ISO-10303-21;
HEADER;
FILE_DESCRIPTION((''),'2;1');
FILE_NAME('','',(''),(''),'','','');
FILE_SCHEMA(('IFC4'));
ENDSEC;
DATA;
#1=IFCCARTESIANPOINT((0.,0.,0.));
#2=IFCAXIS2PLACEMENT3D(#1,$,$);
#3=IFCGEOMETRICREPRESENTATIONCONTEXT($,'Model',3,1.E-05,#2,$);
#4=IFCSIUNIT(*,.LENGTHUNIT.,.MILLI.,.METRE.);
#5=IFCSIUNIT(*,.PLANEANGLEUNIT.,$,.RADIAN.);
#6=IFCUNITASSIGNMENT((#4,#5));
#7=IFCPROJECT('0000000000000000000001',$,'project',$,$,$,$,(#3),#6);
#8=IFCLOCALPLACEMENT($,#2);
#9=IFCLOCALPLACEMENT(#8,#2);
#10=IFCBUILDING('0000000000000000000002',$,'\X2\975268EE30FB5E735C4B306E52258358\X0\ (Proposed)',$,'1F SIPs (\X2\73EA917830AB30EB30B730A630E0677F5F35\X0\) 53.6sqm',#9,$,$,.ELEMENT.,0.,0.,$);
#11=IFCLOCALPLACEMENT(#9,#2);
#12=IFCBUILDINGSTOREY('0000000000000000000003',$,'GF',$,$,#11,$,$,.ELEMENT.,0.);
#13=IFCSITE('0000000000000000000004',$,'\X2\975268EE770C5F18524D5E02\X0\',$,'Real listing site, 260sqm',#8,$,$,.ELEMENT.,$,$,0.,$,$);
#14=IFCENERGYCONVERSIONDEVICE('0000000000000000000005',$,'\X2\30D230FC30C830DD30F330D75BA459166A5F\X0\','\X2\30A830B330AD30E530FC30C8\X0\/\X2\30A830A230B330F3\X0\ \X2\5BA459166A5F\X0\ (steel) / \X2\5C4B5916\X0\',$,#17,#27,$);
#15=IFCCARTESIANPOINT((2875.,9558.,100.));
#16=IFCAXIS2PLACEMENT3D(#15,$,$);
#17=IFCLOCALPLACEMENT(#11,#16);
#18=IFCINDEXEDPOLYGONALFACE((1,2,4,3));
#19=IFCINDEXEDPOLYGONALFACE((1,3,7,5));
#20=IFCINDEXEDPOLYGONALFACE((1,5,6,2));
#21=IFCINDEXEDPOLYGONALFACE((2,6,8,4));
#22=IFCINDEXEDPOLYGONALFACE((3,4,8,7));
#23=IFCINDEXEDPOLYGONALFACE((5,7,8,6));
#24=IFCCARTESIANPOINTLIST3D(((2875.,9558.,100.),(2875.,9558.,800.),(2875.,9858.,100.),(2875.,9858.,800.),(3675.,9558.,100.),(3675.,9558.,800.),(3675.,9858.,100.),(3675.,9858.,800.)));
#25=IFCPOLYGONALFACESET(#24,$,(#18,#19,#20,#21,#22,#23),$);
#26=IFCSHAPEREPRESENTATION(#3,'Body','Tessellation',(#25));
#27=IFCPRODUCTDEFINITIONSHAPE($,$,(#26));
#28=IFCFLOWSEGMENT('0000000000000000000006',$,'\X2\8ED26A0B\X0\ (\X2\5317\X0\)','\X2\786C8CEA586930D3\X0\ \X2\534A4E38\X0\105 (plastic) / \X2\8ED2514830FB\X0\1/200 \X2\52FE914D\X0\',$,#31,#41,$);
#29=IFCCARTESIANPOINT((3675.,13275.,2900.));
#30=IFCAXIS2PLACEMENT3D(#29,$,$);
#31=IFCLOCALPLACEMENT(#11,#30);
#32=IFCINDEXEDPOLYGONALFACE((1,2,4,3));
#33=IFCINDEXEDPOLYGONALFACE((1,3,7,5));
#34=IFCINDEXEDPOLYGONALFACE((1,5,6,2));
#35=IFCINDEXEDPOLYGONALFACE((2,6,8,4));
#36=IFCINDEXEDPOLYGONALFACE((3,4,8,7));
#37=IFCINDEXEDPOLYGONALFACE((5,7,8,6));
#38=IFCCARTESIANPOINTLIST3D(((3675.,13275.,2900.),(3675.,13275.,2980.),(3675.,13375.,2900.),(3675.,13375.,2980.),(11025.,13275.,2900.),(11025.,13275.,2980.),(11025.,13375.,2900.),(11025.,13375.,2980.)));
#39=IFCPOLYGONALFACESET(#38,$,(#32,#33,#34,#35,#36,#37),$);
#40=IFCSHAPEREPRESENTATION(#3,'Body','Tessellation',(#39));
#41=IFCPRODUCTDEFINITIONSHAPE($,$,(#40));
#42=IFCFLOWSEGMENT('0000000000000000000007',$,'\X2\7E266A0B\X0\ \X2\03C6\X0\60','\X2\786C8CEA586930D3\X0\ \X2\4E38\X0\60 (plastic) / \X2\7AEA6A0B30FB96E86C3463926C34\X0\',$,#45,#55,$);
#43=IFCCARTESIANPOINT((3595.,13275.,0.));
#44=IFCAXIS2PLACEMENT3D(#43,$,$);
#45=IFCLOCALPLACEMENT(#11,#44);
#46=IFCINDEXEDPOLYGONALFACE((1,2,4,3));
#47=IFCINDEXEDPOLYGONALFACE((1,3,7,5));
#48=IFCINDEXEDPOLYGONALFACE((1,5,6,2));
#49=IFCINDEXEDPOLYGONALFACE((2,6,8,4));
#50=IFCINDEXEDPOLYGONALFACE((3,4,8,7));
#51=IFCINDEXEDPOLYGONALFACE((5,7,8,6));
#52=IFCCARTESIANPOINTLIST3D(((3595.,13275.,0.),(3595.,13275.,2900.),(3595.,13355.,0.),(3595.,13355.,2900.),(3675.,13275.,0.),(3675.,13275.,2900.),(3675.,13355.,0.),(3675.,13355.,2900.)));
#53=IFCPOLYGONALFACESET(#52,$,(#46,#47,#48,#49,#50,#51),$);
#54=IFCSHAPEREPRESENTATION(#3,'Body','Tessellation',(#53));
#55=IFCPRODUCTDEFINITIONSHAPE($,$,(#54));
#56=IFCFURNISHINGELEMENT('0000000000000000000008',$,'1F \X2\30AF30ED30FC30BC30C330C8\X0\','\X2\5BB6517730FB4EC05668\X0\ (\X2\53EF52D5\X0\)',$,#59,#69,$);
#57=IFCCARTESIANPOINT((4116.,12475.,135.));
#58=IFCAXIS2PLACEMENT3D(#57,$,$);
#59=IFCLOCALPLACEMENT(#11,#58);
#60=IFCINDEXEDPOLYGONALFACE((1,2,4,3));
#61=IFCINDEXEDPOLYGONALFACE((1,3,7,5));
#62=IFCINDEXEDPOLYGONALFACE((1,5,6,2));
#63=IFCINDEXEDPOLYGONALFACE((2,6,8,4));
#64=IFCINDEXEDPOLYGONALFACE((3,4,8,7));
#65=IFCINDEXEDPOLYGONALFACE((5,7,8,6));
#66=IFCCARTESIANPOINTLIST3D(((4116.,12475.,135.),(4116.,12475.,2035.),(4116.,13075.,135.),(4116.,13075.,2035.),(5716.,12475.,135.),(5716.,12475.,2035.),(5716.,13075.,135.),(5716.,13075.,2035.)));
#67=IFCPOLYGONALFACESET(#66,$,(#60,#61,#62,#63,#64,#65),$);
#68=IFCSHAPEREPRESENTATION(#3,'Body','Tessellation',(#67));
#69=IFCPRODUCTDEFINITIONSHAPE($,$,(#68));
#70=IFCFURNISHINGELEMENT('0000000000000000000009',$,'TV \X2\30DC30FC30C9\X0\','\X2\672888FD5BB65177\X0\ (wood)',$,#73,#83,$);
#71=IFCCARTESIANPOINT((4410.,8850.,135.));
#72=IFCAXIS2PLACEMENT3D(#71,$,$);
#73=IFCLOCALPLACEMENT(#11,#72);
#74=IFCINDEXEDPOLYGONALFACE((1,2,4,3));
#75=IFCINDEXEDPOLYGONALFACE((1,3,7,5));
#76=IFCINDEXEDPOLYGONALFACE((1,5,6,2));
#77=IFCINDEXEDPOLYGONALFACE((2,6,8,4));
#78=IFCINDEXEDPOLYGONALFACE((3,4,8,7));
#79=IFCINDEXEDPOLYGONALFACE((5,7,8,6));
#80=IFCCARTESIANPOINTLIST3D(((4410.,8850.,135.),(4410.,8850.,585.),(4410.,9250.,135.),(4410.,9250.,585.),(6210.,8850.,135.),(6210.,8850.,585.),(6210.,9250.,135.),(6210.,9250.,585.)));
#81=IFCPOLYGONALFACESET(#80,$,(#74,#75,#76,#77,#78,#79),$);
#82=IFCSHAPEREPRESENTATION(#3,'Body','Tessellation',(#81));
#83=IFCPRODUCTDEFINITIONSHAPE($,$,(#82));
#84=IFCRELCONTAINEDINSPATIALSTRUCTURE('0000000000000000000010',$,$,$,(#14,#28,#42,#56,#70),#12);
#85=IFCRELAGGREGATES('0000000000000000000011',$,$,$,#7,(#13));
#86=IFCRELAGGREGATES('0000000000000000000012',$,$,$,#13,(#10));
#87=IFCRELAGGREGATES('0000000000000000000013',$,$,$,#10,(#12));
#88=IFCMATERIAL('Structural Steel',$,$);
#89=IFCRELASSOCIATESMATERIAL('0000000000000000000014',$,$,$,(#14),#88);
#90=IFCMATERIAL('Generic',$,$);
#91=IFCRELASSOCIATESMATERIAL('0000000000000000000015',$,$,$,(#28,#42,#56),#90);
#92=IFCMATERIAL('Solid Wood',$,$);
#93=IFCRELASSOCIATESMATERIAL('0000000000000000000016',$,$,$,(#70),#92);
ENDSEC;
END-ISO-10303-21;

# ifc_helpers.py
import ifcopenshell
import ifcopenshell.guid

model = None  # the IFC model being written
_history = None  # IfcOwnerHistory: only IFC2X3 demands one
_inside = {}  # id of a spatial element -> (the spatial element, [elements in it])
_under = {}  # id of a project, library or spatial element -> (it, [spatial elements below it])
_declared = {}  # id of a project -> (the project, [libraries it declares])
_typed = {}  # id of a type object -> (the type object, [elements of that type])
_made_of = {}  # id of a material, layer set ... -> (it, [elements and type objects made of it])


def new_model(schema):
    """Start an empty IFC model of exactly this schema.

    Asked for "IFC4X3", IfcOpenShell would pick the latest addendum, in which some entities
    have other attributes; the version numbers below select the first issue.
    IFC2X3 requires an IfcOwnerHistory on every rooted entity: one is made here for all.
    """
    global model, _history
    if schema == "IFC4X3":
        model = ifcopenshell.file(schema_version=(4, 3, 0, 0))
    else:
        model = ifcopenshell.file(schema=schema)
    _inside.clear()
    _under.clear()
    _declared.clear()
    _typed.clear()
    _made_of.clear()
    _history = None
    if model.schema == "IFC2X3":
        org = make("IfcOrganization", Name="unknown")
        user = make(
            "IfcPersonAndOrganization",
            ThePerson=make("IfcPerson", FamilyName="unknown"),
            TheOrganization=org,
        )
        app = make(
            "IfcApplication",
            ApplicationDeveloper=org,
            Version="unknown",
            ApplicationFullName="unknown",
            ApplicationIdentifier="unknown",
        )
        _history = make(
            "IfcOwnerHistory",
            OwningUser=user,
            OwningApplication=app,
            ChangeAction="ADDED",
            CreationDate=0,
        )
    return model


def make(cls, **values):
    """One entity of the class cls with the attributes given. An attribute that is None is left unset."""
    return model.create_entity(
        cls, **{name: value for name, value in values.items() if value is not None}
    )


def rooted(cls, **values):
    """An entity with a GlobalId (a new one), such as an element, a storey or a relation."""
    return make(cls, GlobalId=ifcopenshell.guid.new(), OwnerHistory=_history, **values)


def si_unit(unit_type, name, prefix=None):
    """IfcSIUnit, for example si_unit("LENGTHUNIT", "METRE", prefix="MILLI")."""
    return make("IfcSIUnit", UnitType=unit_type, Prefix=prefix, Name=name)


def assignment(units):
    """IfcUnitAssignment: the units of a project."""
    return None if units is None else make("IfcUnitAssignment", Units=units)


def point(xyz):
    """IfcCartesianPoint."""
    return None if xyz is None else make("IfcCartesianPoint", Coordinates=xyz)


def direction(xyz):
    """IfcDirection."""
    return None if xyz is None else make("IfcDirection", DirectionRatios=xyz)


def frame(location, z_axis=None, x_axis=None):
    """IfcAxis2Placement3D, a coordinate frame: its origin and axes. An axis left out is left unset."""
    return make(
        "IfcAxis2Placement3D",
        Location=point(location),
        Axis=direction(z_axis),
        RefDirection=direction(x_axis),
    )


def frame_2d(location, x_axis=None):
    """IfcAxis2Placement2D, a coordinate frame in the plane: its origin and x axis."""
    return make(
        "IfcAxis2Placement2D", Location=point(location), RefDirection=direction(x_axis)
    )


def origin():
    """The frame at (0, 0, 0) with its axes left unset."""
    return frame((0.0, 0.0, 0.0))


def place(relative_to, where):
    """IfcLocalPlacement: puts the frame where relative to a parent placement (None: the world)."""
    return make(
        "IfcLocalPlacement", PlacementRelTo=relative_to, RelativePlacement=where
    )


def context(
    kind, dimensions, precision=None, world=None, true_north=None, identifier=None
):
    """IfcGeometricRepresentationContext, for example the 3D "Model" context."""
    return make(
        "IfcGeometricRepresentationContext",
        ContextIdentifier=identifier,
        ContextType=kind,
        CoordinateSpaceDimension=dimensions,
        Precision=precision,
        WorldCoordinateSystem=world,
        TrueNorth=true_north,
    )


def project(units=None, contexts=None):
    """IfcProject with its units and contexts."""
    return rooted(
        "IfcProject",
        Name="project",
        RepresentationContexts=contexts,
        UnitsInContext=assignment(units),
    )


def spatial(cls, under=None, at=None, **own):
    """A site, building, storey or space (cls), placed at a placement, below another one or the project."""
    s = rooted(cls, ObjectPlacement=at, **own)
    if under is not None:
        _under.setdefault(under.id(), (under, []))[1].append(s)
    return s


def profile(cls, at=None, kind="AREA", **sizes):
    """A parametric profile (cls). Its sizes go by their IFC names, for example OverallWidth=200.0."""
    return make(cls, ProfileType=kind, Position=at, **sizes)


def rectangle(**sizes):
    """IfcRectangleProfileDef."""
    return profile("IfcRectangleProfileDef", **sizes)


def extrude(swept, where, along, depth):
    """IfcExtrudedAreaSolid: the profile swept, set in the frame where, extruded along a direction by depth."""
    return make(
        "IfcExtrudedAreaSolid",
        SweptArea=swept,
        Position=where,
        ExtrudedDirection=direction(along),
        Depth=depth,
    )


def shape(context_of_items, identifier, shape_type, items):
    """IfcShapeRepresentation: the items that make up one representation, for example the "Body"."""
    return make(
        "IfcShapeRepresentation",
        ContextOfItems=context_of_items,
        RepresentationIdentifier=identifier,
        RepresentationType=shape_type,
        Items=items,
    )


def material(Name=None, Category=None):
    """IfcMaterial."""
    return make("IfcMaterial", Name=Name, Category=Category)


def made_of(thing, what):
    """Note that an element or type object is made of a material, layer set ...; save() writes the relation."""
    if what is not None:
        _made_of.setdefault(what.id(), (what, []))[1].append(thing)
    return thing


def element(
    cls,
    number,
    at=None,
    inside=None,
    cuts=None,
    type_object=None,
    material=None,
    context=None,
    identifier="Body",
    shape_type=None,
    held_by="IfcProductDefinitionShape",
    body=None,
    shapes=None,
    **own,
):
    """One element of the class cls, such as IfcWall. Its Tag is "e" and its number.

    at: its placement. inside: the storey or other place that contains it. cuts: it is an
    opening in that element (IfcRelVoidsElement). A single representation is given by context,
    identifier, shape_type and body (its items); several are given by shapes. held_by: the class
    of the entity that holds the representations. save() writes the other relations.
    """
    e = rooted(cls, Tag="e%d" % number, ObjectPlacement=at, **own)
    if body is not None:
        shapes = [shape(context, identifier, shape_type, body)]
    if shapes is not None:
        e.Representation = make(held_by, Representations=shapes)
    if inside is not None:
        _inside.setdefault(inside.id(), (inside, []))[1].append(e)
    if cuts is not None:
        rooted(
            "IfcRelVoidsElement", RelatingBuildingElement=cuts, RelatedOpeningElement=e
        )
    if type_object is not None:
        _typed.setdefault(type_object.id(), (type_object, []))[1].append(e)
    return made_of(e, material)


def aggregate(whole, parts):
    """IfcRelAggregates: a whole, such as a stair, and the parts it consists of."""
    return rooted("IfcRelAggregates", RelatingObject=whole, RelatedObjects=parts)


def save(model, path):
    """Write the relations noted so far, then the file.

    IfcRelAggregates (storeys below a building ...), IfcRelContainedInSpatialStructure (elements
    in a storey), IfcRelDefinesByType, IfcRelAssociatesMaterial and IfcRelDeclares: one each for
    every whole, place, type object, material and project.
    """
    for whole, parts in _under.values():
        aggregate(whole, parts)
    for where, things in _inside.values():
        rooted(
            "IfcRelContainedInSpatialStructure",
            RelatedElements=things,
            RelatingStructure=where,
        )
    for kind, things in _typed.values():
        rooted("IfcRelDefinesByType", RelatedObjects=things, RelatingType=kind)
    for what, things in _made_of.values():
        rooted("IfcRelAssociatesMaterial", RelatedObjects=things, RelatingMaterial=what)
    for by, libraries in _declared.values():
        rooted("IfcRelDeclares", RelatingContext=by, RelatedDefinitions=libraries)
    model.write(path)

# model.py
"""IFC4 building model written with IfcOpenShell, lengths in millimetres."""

from ifc_helpers import new_model, si_unit, frame, frame_2d, origin, place, context, project, spatial, rectangle, extrude, material, element, save


model = new_model("IFC4")

# Units and contexts
model_context = context("Model", 3, precision=1e-05, world=origin())
ifc_project = project(units=[si_unit("LENGTHUNIT", "METRE", prefix="MILLI"), si_unit("PLANEANGLEUNIT", "RADIAN")], contexts=[model_context])

# Site, building, storey
site_placement = place(None, origin())
site = spatial("IfcSite", under=ifc_project, at=site_placement, Name="青森県弘前市", ObjectType="Real listing site, 260sqm", CompositionType="ELEMENT", RefElevation=0.0)
building_placement = place(site_placement, origin())
building = spatial("IfcBuilding", under=site, at=building_placement, Name="青森・平屋の別荘 (Proposed)", ObjectType="1F SIPs (珪酸カルシウム板張) 53.6sqm", CompositionType="ELEMENT", ElevationOfRefHeight=0.0, ElevationOfTerrain=0.0)
storey_placement = place(building_placement, origin())
storey = spatial("IfcBuildingStorey", under=building, at=storey_placement, Name="GF", CompositionType="ELEMENT", Elevation=0.0)

# Shared definitions
ifc_material_1 = material(Name="Solid Wood")

# Shared definitions
ifc_material_2 = material(Name="Structural Steel")

# Shared definitions
ifc_material_3 = material(Name="Generic")

# Energy conversion device
energy_conversion_device_placement = place(storey_placement, frame((2875.0, 9558.0, 100.0)))
element("IfcEnergyConversionDevice", 1, at=energy_conversion_device_placement, inside=storey, material=ifc_material_2, Name="ヒートポンプ室外機", Description="エコキュート/エアコン 室外機 (steel) / 屋外", context=model_context, shape_type="SweptSolid", body=[
    extrude(rectangle(XDim=800.0, YDim=300.0, at=frame_2d((400.0, 150.0))), frame((2875.0, 9558.0, 100.0)), (0.0, 0.0, 1.0), 700.0),
])

# Flow segments
flow_segment_1_placement = place(storey_placement, frame((3675.0, 13275.0, 2900.0)))
element("IfcFlowSegment", 2, at=flow_segment_1_placement, inside=storey, material=ifc_material_3, Name="軒樋 (北)", Description="硬質塩ビ 半丸105 (plastic) / 軒先・1/200 勾配", context=model_context, shape_type="SweptSolid", body=[
    extrude(rectangle(XDim=7350.0, YDim=100.0, at=frame_2d((3675.0, 50.0))), frame((3675.0, 13275.0, 2900.0)), (0.0, 0.0, 1.0), 80.0),
])
flow_segment_2_placement = place(storey_placement, frame((3595.0, 13275.0, 0.0)))
element("IfcFlowSegment", 3, at=flow_segment_2_placement, inside=storey, material=ifc_material_3, Name="縦樋 φ60", Description="硬質塩ビ 丸60 (plastic) / 竪樋・雨水排水", context=model_context, shape_type="SweptSolid", body=[
    extrude(rectangle(XDim=80.0, YDim=80.0, at=frame_2d((40.0, 40.0))), frame((3595.0, 13275.0, 0.0)), (0.0, 0.0, 1.0), 2900.0),
])

# Furnishing elements
furnishing_1_placement = place(storey_placement, frame((4116.0, 12475.0, 135.0)))
element("IfcFurnishingElement", 4, at=furnishing_1_placement, inside=storey, material=ifc_material_3, Name="1F クローゼット", Description="家具・什器 (可動)", context=model_context, shape_type="SweptSolid", body=[
    extrude(rectangle(XDim=1600.0, YDim=600.0, at=frame_2d((800.0, 300.0))), frame((4116.0, 12475.0, 135.0)), (0.0, 0.0, 1.0), 1900.0),
])
furnishing_2_placement = place(storey_placement, frame((4410.0, 8850.0, 135.0)))
element("IfcFurnishingElement", 5, at=furnishing_2_placement, inside=storey, material=ifc_material_1, Name="TV ボード", Description="木製家具 (wood)", context=model_context, shape_type="SweptSolid", body=[
    extrude(rectangle(XDim=1800.0, YDim=400.0, at=frame_2d((900.0, 200.0))), frame((4410.0, 8850.0, 135.0)), (0.0, 0.0, 1.0), 450.0),
])

save(model, "model.ifc")
